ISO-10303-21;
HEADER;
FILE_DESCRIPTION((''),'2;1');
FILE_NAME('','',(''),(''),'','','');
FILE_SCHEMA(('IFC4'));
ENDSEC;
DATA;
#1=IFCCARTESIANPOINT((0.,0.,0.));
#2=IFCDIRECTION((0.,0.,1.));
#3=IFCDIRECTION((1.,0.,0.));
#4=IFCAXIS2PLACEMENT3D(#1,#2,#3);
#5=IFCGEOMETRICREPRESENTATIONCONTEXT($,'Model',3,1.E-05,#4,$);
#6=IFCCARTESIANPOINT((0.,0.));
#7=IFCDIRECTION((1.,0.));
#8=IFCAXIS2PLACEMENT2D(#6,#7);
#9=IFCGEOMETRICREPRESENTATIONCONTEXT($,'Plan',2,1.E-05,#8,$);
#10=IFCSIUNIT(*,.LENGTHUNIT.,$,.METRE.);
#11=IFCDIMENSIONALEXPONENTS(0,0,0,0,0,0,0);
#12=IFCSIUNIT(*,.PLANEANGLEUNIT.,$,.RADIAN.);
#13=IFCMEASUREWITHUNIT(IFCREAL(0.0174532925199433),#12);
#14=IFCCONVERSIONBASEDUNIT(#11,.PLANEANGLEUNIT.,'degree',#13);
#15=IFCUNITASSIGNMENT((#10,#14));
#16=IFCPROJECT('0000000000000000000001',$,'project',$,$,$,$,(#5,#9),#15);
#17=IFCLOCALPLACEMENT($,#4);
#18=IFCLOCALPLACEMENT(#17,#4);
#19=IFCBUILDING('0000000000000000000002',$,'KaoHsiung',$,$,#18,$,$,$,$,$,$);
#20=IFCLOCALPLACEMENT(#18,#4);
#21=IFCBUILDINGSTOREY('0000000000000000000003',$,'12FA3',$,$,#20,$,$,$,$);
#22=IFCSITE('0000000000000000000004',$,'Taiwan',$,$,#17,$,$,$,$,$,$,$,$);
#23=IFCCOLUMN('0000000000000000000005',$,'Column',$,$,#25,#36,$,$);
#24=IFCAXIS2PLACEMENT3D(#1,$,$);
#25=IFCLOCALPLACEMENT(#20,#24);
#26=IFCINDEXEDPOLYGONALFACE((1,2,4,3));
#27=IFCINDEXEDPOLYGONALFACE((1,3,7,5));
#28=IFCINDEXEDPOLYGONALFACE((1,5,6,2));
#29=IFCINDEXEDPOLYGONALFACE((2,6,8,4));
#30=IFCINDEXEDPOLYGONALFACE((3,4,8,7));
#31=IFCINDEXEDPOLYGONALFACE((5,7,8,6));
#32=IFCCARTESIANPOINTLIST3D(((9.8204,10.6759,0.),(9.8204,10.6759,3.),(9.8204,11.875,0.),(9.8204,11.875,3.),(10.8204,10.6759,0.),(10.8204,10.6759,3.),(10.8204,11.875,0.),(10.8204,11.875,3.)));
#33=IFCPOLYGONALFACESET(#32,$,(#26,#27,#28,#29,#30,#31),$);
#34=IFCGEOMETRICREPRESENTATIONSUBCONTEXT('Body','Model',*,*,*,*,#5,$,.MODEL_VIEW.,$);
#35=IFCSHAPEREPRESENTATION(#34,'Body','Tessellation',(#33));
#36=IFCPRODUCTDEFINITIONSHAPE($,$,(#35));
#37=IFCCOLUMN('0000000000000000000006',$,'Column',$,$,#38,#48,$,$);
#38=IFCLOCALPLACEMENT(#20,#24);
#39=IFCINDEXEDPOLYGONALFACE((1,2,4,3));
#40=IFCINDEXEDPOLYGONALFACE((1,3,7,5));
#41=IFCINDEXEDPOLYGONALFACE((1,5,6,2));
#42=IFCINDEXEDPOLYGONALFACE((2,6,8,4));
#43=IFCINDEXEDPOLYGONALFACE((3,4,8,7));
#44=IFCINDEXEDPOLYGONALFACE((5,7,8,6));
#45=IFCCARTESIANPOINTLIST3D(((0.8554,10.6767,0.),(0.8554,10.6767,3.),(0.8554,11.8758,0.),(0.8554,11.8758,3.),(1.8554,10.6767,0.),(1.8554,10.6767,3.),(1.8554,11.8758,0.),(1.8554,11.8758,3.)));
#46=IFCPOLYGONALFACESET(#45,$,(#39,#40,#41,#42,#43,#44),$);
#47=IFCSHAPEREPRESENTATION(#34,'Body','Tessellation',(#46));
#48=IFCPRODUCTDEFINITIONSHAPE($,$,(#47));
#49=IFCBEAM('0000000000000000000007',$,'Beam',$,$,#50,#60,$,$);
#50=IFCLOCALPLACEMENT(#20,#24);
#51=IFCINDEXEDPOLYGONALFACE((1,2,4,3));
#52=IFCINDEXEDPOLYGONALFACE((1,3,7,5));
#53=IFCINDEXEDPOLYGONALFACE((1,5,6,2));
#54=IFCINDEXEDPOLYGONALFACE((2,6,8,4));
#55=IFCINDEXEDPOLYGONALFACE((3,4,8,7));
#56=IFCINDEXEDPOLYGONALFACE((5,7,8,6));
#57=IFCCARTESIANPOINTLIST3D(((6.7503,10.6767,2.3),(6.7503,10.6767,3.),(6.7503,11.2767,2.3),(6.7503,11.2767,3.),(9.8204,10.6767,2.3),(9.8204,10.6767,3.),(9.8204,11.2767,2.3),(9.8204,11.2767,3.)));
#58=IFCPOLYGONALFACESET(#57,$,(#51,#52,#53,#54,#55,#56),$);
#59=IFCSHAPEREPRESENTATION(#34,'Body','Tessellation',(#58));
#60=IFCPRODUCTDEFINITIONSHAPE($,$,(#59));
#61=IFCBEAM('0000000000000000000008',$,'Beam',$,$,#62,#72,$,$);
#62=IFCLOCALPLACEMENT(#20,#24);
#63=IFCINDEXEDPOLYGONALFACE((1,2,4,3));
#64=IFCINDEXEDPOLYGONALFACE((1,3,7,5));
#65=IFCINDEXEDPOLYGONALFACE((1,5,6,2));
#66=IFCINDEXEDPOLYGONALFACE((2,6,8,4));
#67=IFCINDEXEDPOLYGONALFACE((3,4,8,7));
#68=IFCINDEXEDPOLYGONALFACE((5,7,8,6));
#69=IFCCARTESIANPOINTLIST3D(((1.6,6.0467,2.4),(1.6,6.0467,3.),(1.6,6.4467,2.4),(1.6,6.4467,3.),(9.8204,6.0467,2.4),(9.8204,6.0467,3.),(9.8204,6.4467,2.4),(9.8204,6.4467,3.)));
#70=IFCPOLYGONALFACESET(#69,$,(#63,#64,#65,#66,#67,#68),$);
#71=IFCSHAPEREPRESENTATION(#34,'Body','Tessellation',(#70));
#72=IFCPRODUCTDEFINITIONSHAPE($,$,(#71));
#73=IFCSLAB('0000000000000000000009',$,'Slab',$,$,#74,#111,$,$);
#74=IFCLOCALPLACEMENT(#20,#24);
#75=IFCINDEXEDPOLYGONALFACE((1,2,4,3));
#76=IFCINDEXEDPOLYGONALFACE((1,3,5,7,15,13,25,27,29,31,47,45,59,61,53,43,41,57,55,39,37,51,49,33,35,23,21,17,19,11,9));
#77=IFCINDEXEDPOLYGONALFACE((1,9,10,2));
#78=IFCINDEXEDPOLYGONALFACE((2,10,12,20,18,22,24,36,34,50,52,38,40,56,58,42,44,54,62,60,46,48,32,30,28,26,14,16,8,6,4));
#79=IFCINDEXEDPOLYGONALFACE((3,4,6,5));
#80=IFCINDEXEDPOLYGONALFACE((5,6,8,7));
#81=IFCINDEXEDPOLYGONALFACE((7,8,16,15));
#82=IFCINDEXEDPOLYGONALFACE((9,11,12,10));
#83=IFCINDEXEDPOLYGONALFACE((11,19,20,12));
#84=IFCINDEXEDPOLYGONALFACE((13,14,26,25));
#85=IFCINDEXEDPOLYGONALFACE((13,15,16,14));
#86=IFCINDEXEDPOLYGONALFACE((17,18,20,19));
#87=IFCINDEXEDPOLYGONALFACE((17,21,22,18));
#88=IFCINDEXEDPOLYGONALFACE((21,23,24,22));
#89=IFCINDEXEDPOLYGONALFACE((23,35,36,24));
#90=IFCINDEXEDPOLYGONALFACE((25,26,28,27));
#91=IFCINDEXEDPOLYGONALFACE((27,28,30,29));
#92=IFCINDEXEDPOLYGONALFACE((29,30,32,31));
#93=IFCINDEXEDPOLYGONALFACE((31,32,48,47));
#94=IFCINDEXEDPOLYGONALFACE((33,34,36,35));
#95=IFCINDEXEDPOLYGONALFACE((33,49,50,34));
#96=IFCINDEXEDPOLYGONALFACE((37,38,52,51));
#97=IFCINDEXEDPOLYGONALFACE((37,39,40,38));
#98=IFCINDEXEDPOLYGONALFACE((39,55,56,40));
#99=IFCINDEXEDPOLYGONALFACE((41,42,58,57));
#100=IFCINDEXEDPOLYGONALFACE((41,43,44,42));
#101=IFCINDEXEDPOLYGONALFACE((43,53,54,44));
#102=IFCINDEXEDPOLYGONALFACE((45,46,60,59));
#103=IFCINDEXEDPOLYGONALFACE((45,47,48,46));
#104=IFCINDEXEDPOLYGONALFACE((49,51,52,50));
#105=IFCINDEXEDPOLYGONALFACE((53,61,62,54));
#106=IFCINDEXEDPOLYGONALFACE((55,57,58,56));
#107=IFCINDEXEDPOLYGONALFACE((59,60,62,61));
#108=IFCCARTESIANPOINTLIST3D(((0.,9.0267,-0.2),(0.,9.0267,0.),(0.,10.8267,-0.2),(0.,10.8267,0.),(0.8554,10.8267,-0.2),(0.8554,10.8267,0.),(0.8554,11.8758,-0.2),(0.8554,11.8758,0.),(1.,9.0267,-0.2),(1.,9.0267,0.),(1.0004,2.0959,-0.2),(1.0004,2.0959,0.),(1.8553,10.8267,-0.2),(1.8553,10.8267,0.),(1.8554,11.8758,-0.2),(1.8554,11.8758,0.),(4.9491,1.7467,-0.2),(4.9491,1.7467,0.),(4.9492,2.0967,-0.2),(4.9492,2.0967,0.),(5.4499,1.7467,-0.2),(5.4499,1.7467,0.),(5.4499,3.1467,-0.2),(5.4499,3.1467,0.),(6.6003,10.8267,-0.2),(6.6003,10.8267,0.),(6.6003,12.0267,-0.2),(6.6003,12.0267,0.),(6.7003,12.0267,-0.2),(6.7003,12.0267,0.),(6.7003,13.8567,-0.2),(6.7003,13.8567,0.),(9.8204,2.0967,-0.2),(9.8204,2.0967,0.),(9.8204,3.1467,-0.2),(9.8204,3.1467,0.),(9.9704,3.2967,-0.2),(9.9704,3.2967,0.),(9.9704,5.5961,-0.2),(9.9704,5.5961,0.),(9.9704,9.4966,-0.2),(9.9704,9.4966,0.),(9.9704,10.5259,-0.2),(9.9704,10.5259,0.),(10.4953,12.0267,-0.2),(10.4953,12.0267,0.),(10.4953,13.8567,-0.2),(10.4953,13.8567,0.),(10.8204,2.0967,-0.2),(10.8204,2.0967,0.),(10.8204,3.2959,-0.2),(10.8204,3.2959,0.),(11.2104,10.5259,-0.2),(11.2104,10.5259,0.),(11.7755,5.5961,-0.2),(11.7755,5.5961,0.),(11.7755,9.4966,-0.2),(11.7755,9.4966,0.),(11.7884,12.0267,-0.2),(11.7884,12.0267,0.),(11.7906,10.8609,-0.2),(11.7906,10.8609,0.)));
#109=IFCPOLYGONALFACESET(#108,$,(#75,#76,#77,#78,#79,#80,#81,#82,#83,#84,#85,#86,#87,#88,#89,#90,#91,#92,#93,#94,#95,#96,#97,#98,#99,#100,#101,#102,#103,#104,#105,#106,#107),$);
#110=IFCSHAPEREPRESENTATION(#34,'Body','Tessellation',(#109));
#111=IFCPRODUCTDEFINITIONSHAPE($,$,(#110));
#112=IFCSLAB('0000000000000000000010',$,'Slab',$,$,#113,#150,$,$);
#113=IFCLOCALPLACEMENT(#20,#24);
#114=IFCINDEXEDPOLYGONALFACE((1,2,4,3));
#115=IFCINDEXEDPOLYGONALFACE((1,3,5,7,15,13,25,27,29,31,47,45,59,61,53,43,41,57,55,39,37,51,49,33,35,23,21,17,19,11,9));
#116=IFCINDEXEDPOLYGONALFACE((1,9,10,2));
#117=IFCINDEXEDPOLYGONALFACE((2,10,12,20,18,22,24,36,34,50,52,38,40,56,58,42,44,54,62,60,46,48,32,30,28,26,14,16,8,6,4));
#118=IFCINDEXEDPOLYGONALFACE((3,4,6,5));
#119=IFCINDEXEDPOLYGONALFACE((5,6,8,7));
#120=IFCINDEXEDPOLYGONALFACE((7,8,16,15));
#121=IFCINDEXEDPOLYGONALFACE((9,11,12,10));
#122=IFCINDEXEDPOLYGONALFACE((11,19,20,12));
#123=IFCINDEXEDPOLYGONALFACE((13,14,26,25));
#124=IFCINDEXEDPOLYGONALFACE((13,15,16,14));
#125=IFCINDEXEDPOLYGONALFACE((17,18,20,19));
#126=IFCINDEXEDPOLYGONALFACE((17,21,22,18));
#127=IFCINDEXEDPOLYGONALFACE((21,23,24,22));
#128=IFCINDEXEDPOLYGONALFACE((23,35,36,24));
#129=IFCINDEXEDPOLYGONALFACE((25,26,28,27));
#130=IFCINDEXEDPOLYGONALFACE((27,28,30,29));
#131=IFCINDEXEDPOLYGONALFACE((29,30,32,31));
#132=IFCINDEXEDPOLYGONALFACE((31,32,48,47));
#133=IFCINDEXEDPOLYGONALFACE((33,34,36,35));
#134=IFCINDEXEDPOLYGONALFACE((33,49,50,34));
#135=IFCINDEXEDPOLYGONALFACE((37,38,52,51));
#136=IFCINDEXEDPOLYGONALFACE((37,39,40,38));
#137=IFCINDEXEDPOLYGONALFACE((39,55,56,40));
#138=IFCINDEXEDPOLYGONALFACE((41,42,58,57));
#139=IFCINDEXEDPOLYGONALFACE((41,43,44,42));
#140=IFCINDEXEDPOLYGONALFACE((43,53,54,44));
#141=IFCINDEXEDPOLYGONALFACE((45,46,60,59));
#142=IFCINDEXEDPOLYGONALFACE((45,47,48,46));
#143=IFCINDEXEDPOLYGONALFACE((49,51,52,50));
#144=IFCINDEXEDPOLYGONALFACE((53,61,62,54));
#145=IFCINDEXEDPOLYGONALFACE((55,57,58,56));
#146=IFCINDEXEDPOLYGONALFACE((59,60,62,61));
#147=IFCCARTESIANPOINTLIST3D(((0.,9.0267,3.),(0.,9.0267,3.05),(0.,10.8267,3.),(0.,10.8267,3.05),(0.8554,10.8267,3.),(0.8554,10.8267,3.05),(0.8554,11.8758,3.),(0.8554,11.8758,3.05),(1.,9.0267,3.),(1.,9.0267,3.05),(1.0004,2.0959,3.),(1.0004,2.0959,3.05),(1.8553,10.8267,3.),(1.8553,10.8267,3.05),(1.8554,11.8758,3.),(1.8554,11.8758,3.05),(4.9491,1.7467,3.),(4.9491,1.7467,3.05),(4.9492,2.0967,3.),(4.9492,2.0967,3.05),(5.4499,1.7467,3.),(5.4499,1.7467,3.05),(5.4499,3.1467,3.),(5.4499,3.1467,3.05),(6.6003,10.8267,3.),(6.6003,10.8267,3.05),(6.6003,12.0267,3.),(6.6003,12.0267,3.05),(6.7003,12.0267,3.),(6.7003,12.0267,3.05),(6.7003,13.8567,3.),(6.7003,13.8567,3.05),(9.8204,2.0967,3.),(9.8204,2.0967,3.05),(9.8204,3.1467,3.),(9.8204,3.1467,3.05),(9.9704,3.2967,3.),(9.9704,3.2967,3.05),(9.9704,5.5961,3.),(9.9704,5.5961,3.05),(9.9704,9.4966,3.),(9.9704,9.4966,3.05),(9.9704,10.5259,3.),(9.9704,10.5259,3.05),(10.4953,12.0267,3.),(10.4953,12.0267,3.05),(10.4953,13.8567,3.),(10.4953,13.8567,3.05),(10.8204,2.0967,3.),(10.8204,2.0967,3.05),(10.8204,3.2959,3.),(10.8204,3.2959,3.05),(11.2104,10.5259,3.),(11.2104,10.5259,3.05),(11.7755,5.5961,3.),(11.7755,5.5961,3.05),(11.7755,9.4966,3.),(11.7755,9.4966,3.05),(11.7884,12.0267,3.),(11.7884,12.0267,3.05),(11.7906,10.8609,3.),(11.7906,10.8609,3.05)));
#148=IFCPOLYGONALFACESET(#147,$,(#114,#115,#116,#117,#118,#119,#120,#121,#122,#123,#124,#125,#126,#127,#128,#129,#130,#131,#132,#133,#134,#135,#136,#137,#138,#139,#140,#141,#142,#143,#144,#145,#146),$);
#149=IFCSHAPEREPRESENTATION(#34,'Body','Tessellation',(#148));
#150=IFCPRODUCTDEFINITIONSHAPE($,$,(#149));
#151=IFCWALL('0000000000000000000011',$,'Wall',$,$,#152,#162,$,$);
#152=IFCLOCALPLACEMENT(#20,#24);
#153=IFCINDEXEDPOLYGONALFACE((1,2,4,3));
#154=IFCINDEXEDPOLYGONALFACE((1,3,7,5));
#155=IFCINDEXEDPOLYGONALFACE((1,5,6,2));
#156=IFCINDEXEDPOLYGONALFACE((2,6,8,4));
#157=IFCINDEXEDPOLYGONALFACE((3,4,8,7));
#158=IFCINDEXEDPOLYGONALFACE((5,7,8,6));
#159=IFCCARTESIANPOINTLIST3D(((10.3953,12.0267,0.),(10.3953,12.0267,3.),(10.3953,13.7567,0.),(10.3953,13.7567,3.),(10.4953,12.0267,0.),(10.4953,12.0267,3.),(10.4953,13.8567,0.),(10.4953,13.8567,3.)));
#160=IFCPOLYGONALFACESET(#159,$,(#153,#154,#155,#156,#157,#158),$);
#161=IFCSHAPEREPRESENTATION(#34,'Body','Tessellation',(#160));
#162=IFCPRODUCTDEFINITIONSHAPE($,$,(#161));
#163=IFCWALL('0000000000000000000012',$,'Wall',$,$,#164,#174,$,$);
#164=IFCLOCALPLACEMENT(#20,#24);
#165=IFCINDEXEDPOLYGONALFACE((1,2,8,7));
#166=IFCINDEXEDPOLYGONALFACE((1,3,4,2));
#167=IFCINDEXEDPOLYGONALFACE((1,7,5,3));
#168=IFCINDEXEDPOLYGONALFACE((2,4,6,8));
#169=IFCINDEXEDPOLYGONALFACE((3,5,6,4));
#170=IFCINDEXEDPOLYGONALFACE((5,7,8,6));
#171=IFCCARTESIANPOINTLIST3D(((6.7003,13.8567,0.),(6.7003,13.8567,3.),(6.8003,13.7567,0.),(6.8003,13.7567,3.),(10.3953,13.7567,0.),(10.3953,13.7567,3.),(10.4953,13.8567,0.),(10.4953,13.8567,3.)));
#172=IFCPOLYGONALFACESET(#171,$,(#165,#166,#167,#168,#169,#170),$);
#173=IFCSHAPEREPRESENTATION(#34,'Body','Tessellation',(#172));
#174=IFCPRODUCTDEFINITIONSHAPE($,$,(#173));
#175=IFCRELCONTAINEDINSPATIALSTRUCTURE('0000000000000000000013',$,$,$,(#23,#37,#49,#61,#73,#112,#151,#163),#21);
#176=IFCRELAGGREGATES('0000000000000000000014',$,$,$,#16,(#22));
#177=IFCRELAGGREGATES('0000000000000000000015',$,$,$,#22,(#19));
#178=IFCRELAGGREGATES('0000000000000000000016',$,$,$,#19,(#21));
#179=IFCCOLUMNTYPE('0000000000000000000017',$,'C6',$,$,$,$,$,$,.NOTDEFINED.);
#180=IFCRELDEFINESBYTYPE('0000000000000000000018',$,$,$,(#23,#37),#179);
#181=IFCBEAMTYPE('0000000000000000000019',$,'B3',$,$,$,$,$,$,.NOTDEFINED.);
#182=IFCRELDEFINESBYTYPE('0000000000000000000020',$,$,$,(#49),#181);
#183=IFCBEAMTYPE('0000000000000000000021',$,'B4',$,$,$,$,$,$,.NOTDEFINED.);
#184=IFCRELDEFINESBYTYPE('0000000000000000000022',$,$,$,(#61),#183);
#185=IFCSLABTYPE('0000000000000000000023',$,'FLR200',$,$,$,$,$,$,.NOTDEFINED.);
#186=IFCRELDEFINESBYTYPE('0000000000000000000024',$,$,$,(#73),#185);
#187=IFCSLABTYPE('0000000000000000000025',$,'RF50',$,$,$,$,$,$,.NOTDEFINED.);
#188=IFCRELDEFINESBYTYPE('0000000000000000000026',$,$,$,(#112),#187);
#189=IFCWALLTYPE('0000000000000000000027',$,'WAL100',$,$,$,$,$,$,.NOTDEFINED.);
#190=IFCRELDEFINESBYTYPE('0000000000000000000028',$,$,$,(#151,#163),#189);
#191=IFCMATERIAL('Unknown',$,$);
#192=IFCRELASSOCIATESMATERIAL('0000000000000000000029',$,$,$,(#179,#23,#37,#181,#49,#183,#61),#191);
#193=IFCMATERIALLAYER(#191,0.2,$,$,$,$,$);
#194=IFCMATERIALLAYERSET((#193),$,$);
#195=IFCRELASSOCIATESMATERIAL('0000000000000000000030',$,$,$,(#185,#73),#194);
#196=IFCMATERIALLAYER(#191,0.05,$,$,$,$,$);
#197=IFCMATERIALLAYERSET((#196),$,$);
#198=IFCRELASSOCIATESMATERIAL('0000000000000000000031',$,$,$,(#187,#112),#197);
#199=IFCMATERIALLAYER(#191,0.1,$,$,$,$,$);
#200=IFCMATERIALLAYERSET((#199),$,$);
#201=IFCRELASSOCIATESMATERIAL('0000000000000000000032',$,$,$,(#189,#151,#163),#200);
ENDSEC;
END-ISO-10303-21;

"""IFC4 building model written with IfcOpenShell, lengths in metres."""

from ifc_helpers import new_model, entity, si_unit, converted_unit, frame, origin_with_axes, origin_2d_with_axis, place, context, subcontext, project, spatial, line, indexed_curve, rectangle, outline, extrude, material, layer, layer_set, layer_usage, material_profile, profile_set, profile_usage, type_object, element, save


model = new_model("IFC4")

# Units and contexts
model_context = context("Model", 3, precision=1e-05, world=origin_with_axes())
plan_context = context("Plan", 2, precision=1e-05, world=origin_2d_with_axis())
body_context_1 = subcontext(model_context, "Body", "Model", "MODEL_VIEW")
ifc_project = project(units=[si_unit("LENGTHUNIT", "METRE"), converted_unit("PLANEANGLEUNIT", "degree", entity("IfcReal", 0.0174532925199433), si_unit("PLANEANGLEUNIT", "RADIAN"), dimensions=[0, 0, 0, 0, 0, 0, 0])], contexts=[model_context, plan_context])

# Site, building, storey
site_placement = place(None, origin_with_axes())
site = spatial("IfcSite", under=ifc_project, at=site_placement, Name="Taiwan")
building_placement = place(site_placement, origin_with_axes())
building = spatial("IfcBuilding", under=site, at=building_placement, Name="KaoHsiung")
storey_placement = place(building_placement, origin_with_axes())
storey = spatial("IfcBuildingStorey", under=building, at=storey_placement, Name="12FA3")

# Columns
ifc_material = material(Name="Unknown")
ifc_material_profile_1 = material_profile(ifc_material, outline(indexed_curve([(0.0, 1.1992), (1.0, 1.1992), (1.0, 0.0), (0.0, 0.0), (0.0, 1.1992)])))
ifc_profile_set_1 = profile_set([ifc_material_profile_1])
ifc_profile_usage_1 = profile_usage(ifc_profile_set_1, cardinal=5)
column_type = type_object("IfcColumnType", Name="C6", PredefinedType="NOTDEFINED", material=ifc_profile_set_1)
column_1_placement = place(storey_placement, frame((9.8204, 10.6759, 0.0), z_axis=(0.0, 0.0, 1.0), x_axis=(1.0, 0.0, 0.0)))
element("IfcColumn", 1, at=column_1_placement, inside=storey, type_object=column_type, material=ifc_profile_usage_1, Name="Column", context=body_context_1, shape_type="SweptSolid", body=[
    extrude(outline(indexed_curve([(0.0, 1.1992), (1.0, 1.1992), (1.0, 0.0), (0.0, 0.0), (0.0, 1.1992)])), origin_with_axes(), (0.0, 0.0, 1.0), 3.0),
])
ifc_profile_usage_2 = profile_usage(ifc_profile_set_1, cardinal=5)
column_2_placement = place(storey_placement, frame((0.8554, 10.6767, 0.0), z_axis=(0.0, 0.0, 1.0), x_axis=(1.0, 0.0, 0.0)))
element("IfcColumn", 2, at=column_2_placement, inside=storey, type_object=column_type, material=ifc_profile_usage_2, Name="Column", context=body_context_1, shape_type="SweptSolid", body=[
    extrude(outline(indexed_curve([(0.0, 1.1992), (1.0, 1.1992), (1.0, 0.0), (0.0, 0.0), (0.0, 1.1992)])), origin_with_axes(), (0.0, 0.0, 1.0), 3.0),
])

# Beams
ifc_material_profile_2 = material_profile(ifc_material, rectangle(XDim=0.6, YDim=0.7, kind="CURVE"))
ifc_profile_set_2 = profile_set([ifc_material_profile_2])
ifc_profile_usage_3 = profile_usage(ifc_profile_set_2, cardinal=9)
beam_type_1 = type_object("IfcBeamType", Name="B3", PredefinedType="NOTDEFINED", material=ifc_profile_set_2)
beam_1_placement = place(storey_placement, frame((6.7503, 10.6767, 3.0), z_axis=(1.0, 0.0, 0.0), x_axis=(0.0, 1.0, 0.0)))
element("IfcBeam", 3, at=beam_1_placement, inside=storey, type_object=beam_type_1, material=ifc_profile_usage_3, Name="Beam", context=body_context_1, shape_type="SweptSolid", body=[
    extrude(rectangle(XDim=0.6, YDim=0.7, kind="CURVE"), frame((0.3, -0.35, 0.0), z_axis=(0.0, 0.0, 1.0), x_axis=(1.0, 0.0, 0.0)), (0.0, 0.0, 1.0), 3.0701),
])
ifc_material_profile_3 = material_profile(ifc_material, rectangle(XDim=0.4, YDim=0.6, kind="CURVE"))
ifc_profile_set_3 = profile_set([ifc_material_profile_3])
ifc_profile_usage_4 = profile_usage(ifc_profile_set_3, cardinal=7)
beam_type_2 = type_object("IfcBeamType", Name="B4", PredefinedType="NOTDEFINED", material=ifc_profile_set_3)
beam_2_placement = place(storey_placement, frame((1.6, 6.4467, 3.0), z_axis=(1.0, 0.0, 0.0), x_axis=(0.0, 1.0, 0.0)))
element("IfcBeam", 4, at=beam_2_placement, inside=storey, type_object=beam_type_2, material=ifc_profile_usage_4, Name="Beam", context=body_context_1, shape_type="SweptSolid", body=[
    extrude(rectangle(XDim=0.4, YDim=0.6, kind="CURVE"), frame((-0.2, -0.3, 0.0), z_axis=(0.0, 0.0, 1.0), x_axis=(1.0, 0.0, 0.0)), (0.0, 0.0, 1.0), 8.2203),
])

# Slabs
ifc_layer_1 = layer(ifc_material, 0.2)
ifc_layer_set_1 = layer_set([ifc_layer_1])
ifc_layer_usage_1 = layer_usage(ifc_layer_set_1, "AXIS3", "POSITIVE", -0.2)
slab_type_1 = type_object("IfcSlabType", Name="FLR200", PredefinedType="NOTDEFINED", material=ifc_layer_set_1)
slab_1_placement = place(storey_placement, frame((0.0, 10.8267, 0.0), z_axis=(0.0, 0.0, 1.0), x_axis=(1.0, 0.0, 0.0)))
element("IfcSlab", 5, at=slab_1_placement, inside=storey, type_object=slab_type_1, material=ifc_layer_usage_1, Name="Slab", context=body_context_1, shape_type="SweptSolid", body=[
    extrude(outline(indexed_curve([(0.0, 0.0), (0.0, -1.8), (1.0, -1.8), (1.0004, -8.7308), (4.9492, -8.73), (4.9491, -9.08), (5.4499, -9.08), (5.4499, -7.68), (9.8203, -7.68), (9.8203, -8.73), (10.8203, -8.73), (10.8203, -7.5308), (9.9703, -7.53), (9.9703, -5.2306), (11.7754, -5.2306), (11.7754, -1.3301), (9.9703, -1.3301), (9.9703, -0.3008), (11.2103, -0.3008), (11.7906, 0.0342), (11.7884, 1.2), (10.4952, 1.2), (10.4952, 3.03), (6.7002, 3.03), (6.7002, 1.2001), (6.6003, 1.2), (6.6003, 0.0), (1.8552, 0.0), (1.8553, 1.0492), (0.8553, 1.0492), (0.8553, 0.0), (0.0, 0.0)])), frame((0.0, 0.0, -0.2), z_axis=(0.0, 0.0, 1.0), x_axis=(1.0, 0.0, 0.0)), (0.0, 0.0, 1.0), 0.2),
])
ifc_layer_2 = layer(ifc_material, 0.05)
ifc_layer_set_2 = layer_set([ifc_layer_2])
ifc_layer_usage_2 = layer_usage(ifc_layer_set_2, "AXIS3", "POSITIVE", 0.0)
slab_type_2 = type_object("IfcSlabType", Name="RF50", PredefinedType="NOTDEFINED", material=ifc_layer_set_2)
slab_2_placement = place(storey_placement, frame((0.0, 10.8267, 3.0), z_axis=(0.0, 0.0, 1.0), x_axis=(1.0, 0.0, 0.0)))
element("IfcSlab", 6, at=slab_2_placement, inside=storey, type_object=slab_type_2, material=ifc_layer_usage_2, Name="Slab", context=body_context_1, shape_type="SweptSolid", body=[
    extrude(outline(indexed_curve([(0.0, 0.0), (0.0, -1.8), (1.0, -1.8), (1.0004, -8.7308), (4.9492, -8.73), (4.9491, -9.08), (5.4499, -9.08), (5.4499, -7.68), (9.8203, -7.68), (9.8203, -8.73), (10.8203, -8.73), (10.8203, -7.5308), (9.9703, -7.53), (9.9703, -5.2306), (11.7754, -5.2306), (11.7754, -1.3301), (9.9703, -1.3301), (9.9703, -0.3008), (11.2103, -0.3008), (11.7906, 0.0342), (11.7884, 1.2), (10.4952, 1.2), (10.4952, 3.03), (6.7002, 3.03), (6.7002, 1.2001), (6.6003, 1.2), (6.6003, 0.0), (1.8552, 0.0), (1.8553, 1.0492), (0.8553, 1.0492), (0.8553, 0.0), (0.0, 0.0)])), None, (0.0, 0.0, 1.0), 0.05),
])

# Walls
ifc_layer_3 = layer(ifc_material, 0.1)
ifc_layer_set_3 = layer_set([ifc_layer_3])
ifc_layer_usage_3 = layer_usage(ifc_layer_set_3, "AXIS2", "POSITIVE", 0.0)
wall_type_1 = type_object("IfcWallType", Name="WAL100", PredefinedType="NOTDEFINED", material=ifc_layer_set_3)
wall_1_placement = place(storey_placement, frame((10.4953, 12.0267, 0.0), z_axis=(0.0, 0.0, 1.0), x_axis=(0.0, 1.0, 0.0)))
element("IfcWall", 7, at=wall_1_placement, inside=storey, type_object=wall_type_1, material=ifc_layer_usage_3, Name="Wall", context=body_context_1, shape_type="SweptSolid", body=[
    extrude(outline(indexed_curve([(0.0, 0.0), (0.0, 0.1), (1.73, 0.1), (1.83, 0.0)], segments=[line(1, 2, 3, 4, 1)])), origin_with_axes(), (0.0, 0.0, 1.0), 3.0),
])
ifc_layer_usage_4 = layer_usage(ifc_layer_set_3, "AXIS2", "POSITIVE", 0.0)
wall_2_placement = place(storey_placement, frame((10.4953, 13.8567, 0.0), z_axis=(0.0, 0.0, 1.0), x_axis=(-1.0, 0.0, 0.0)))
element("IfcWall", 8, at=wall_2_placement, inside=storey, type_object=wall_type_1, material=ifc_layer_usage_4, Name="Wall", context=body_context_1, shape_type="SweptSolid", body=[
    extrude(outline(indexed_curve([(0.0, 0.0), (0.1, 0.1), (3.695, 0.1), (3.795, 0.0)], segments=[line(1, 2, 3, 4, 1)])), origin_with_axes(), (0.0, 0.0, 1.0), 3.0),
])

save(model, "model.ifc")
